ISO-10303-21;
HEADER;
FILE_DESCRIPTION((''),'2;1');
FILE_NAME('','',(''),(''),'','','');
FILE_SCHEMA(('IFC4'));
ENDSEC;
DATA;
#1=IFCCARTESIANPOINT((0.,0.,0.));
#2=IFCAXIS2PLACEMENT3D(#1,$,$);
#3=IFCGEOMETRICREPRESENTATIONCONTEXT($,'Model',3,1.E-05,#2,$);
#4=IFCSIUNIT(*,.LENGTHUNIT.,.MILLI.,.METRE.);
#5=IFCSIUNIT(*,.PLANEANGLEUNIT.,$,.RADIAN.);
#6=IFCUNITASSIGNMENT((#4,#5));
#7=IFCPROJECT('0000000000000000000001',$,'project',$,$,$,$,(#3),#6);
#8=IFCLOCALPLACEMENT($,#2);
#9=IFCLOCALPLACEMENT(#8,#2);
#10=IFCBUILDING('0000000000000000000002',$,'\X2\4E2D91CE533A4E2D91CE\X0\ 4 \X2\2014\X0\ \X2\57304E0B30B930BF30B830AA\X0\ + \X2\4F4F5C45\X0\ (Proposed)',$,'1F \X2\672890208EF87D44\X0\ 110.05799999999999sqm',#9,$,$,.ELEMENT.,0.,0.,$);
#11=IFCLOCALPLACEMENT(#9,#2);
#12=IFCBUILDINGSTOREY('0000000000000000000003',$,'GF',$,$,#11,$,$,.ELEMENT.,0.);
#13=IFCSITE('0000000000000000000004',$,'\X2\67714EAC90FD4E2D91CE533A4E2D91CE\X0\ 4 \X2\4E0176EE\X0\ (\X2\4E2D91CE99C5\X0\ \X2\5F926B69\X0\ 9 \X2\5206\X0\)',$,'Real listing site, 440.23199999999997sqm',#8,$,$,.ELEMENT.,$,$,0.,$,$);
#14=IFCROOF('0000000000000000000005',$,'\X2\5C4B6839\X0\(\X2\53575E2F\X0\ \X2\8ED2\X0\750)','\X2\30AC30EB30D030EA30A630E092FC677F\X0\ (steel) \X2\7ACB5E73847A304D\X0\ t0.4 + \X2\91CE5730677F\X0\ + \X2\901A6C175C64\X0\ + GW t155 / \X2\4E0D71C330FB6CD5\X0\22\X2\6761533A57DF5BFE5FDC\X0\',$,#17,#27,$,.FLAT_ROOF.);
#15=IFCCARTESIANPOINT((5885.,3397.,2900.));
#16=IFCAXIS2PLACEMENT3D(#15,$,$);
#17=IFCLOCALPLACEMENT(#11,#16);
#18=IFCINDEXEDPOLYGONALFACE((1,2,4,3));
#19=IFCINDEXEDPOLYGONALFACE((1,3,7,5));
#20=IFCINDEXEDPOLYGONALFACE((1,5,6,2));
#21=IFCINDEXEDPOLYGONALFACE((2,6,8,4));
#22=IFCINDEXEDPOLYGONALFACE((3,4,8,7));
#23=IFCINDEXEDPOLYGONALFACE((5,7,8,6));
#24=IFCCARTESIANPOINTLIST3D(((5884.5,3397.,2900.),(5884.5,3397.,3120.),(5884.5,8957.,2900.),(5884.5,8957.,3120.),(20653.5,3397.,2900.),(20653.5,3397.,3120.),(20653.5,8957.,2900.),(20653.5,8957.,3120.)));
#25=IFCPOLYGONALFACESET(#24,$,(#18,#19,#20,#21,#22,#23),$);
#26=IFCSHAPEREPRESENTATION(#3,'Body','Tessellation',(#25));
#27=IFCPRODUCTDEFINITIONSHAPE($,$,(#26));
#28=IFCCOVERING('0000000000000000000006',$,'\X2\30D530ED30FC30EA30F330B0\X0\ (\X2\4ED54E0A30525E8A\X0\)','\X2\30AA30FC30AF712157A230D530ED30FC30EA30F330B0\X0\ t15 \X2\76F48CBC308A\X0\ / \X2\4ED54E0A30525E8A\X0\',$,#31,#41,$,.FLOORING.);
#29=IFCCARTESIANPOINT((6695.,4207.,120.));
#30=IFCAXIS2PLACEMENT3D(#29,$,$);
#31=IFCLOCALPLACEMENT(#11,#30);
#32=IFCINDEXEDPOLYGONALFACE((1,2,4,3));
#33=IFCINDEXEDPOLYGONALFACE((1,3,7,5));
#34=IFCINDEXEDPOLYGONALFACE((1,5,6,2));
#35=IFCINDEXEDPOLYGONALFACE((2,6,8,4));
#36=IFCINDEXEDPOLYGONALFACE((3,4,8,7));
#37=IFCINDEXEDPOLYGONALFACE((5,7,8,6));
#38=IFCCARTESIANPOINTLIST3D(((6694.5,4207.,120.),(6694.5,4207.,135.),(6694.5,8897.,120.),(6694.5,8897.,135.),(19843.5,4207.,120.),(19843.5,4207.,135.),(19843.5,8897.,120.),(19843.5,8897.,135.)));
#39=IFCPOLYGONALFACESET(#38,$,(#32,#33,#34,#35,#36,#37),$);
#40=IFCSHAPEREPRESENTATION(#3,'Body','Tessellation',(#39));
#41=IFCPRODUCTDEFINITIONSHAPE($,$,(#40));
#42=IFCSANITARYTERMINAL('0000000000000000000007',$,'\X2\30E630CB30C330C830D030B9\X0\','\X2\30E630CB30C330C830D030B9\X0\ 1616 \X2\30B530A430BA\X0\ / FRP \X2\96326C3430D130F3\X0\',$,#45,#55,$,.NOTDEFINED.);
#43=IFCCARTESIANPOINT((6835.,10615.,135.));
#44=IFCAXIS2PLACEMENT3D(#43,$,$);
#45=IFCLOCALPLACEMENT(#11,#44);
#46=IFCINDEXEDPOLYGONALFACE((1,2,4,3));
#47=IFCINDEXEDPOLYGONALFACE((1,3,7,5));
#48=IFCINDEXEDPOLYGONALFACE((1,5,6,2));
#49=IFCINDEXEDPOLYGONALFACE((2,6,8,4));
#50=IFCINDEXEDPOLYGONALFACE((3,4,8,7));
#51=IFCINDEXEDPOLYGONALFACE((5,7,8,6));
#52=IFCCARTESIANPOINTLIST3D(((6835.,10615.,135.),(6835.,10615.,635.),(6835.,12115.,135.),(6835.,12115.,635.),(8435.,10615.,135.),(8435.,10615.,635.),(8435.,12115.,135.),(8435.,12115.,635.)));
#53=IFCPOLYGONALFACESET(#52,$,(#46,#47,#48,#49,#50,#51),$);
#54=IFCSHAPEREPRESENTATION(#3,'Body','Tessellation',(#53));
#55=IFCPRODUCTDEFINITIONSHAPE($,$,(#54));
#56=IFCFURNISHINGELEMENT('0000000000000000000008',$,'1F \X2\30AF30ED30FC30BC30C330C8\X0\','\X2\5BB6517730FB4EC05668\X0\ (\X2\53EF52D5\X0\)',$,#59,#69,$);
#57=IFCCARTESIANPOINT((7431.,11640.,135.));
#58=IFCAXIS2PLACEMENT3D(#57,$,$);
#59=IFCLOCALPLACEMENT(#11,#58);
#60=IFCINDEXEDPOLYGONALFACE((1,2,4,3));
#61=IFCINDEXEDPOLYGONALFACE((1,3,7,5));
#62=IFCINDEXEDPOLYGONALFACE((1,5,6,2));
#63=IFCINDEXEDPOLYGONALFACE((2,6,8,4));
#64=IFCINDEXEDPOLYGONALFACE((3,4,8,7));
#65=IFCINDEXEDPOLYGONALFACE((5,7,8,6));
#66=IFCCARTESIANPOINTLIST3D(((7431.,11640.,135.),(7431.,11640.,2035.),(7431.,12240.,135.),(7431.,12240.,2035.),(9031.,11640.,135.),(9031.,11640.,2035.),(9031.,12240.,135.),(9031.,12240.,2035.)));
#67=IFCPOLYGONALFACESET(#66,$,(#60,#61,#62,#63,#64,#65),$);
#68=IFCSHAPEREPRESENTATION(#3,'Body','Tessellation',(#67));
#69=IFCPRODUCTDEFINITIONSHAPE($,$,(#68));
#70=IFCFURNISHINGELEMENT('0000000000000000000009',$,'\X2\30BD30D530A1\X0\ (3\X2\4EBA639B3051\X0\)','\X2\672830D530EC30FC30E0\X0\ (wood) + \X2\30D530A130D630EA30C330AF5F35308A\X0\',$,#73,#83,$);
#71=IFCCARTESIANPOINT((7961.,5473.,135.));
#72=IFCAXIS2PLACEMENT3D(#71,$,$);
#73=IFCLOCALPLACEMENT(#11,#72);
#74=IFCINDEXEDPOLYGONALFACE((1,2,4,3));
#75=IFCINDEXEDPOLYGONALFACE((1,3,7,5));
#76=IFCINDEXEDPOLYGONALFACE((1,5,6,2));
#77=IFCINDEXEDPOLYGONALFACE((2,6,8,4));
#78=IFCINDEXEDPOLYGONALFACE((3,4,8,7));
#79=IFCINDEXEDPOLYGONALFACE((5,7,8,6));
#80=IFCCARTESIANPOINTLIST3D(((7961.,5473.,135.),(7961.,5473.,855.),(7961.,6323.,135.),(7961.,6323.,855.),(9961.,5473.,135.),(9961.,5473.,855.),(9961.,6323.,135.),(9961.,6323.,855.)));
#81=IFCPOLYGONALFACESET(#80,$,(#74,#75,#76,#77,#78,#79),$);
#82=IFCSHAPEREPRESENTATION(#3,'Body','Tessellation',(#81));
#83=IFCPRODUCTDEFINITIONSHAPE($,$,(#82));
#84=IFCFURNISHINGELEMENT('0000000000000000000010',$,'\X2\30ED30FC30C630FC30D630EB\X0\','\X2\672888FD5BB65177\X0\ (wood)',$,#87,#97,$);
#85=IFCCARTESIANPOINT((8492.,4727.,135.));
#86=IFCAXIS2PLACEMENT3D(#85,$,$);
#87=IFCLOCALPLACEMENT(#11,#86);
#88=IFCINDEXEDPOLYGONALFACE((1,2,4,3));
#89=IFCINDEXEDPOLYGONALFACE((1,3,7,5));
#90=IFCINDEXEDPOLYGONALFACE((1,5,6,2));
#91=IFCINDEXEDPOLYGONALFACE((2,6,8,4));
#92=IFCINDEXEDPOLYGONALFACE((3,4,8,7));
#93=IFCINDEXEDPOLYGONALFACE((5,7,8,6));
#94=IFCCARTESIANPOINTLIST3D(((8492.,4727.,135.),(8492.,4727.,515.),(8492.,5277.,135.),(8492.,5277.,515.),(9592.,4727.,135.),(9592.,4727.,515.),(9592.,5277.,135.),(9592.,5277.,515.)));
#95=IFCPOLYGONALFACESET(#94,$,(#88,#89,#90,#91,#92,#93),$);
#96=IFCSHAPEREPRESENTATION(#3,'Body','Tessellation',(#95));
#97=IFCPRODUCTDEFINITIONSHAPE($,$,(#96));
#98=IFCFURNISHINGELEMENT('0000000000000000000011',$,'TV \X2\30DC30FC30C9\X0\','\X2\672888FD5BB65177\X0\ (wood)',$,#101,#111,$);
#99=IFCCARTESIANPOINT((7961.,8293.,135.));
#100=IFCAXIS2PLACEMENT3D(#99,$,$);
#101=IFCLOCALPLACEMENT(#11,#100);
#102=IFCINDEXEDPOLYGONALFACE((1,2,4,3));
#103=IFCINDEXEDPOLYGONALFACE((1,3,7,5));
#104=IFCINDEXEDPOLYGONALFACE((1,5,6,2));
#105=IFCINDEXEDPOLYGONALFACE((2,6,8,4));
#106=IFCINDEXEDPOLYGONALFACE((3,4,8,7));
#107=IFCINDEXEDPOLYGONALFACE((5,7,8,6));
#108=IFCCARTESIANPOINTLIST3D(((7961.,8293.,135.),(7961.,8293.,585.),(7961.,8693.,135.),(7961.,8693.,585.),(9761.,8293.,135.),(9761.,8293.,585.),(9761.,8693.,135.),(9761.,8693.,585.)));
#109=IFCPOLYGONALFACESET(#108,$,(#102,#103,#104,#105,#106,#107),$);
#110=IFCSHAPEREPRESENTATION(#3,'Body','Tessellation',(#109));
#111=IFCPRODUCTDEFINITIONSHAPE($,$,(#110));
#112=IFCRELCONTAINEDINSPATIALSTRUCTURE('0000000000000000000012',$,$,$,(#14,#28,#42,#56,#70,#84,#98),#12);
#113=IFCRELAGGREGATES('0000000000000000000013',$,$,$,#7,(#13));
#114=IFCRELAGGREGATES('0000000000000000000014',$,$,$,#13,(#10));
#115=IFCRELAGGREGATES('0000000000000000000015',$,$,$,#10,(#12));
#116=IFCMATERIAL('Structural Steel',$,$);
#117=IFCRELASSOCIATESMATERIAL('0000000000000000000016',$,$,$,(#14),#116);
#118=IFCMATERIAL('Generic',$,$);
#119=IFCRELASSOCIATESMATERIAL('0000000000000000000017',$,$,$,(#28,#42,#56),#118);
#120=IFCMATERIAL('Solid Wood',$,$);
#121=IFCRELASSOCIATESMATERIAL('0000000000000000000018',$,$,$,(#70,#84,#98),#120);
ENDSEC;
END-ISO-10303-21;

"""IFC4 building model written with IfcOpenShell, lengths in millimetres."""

from ifc_helpers import new_model, si_unit, frame, frame_2d, origin, place, context, project, spatial, rectangle, extrude, material, element, save


model = new_model("IFC4")

# Units and contexts
model_context = context("Model", 3, precision=1e-05, world=origin())
ifc_project = project(units=[si_unit("LENGTHUNIT", "METRE", prefix="MILLI"), si_unit("PLANEANGLEUNIT", "RADIAN")], contexts=[model_context])

# Site, building, storey
site_placement = place(None, origin())
site = spatial("IfcSite", under=ifc_project, at=site_placement, Name="東京都中野区中野 4 丁目 (中野駅 徒歩 9 分)", ObjectType="Real listing site, 440.23199999999997sqm", CompositionType="ELEMENT", RefElevation=0.0)
building_placement = place(site_placement, origin())
building = spatial("IfcBuilding", under=site, at=building_placement, Name="中野区中野 4 — 地下スタジオ + 住居 (Proposed)", ObjectType="1F 木造軸組 110.05799999999999sqm", CompositionType="ELEMENT", ElevationOfRefHeight=0.0, ElevationOfTerrain=0.0)
storey_placement = place(building_placement, origin())
storey = spatial("IfcBuildingStorey", under=building, at=storey_placement, Name="GF", CompositionType="ELEMENT", Elevation=0.0)

# Shared definitions
ifc_material_1 = material(Name="Solid Wood")

# Roof
ifc_material_2 = material(Name="Structural Steel")
roof_1_placement = place(storey_placement, frame((5885.0, 3397.0, 2900.0)))
element("IfcRoof", 1, at=roof_1_placement, inside=storey, material=ifc_material_2, Name="屋根(南帯 軒750)", Description="ガルバリウム鋼板 (steel) 立平葺き t0.4 + 野地板 + 通気層 + GW t155 / 不燃・法22条区域対応", PredefinedType="FLAT_ROOF", context=model_context, shape_type="SweptSolid", body=[
    extrude(rectangle(XDim=14769.0, YDim=5560.0, at=frame_2d((7384.0, 2780.0))), frame((5885.0, 3397.0, 2900.0)), (0.0, 0.0, 1.0), 220.0),
])

# Covering
ifc_material_3 = material(Name="Generic")
covering_1_placement = place(storey_placement, frame((6695.0, 4207.0, 120.0)))
element("IfcCovering", 2, at=covering_1_placement, inside=storey, material=ifc_material_3, Name="フローリング (仕上げ床)", Description="オーク無垢フローリング t15 直貼り / 仕上げ床", PredefinedType="FLOORING", context=model_context, shape_type="SweptSolid", body=[
    extrude(rectangle(XDim=13149.0, YDim=4690.0, at=frame_2d((6574.0, 2345.0))), frame((6695.0, 4207.0, 120.0)), (0.0, 0.0, 1.0), 15.0),
])

# Sanitary terminal
sanitary_terminal_placement = place(storey_placement, frame((6835.0, 10615.0, 135.0)))
element("IfcSanitaryTerminal", 3, at=sanitary_terminal_placement, inside=storey, material=ifc_material_3, Name="ユニットバス", Description="ユニットバス 1616 サイズ / FRP 防水パン", PredefinedType="NOTDEFINED", context=model_context, shape_type="SweptSolid", body=[
    extrude(rectangle(XDim=1600.0, YDim=1500.0, at=frame_2d((800.0, 750.0))), frame((6835.0, 10615.0, 135.0)), (0.0, 0.0, 1.0), 500.0),
])

# Furnishing elements
furnishing_1_placement = place(storey_placement, frame((7431.0, 11640.0, 135.0)))
element("IfcFurnishingElement", 4, at=furnishing_1_placement, inside=storey, material=ifc_material_3, Name="1F クローゼット", Description="家具・什器 (可動)", context=model_context, shape_type="SweptSolid", body=[
    extrude(rectangle(XDim=1600.0, YDim=600.0, at=frame_2d((800.0, 300.0))), frame((7431.0, 11640.0, 135.0)), (0.0, 0.0, 1.0), 1900.0),
])
furnishing_2_placement = place(storey_placement, frame((7961.0, 5473.0, 135.0)))
element("IfcFurnishingElement", 5, at=furnishing_2_placement, inside=storey, material=ifc_material_1, Name="ソファ (3人掛け)", Description="木フレーム (wood) + ファブリック張り", context=model_context, shape_type="SweptSolid", body=[
    extrude(rectangle(XDim=2000.0, YDim=850.0, at=frame_2d((1000.0, 425.0))), frame((7961.0, 5473.0, 135.0)), (0.0, 0.0, 1.0), 720.0),
])
furnishing_3_placement = place(storey_placement, frame((8492.0, 4727.0, 135.0)))
element("IfcFurnishingElement", 6, at=furnishing_3_placement, inside=storey, material=ifc_material_1, Name="ローテーブル", Description="木製家具 (wood)", context=model_context, shape_type="SweptSolid", body=[
    extrude(rectangle(XDim=1100.0, YDim=550.0, at=frame_2d((550.0, 275.0))), frame((8492.0, 4727.0, 135.0)), (0.0, 0.0, 1.0), 380.0),
])
furnishing_4_placement = place(storey_placement, frame((7961.0, 8293.0, 135.0)))
element("IfcFurnishingElement", 7, at=furnishing_4_placement, inside=storey, material=ifc_material_1, Name="TV ボード", Description="木製家具 (wood)", context=model_context, shape_type="SweptSolid", body=[
    extrude(rectangle(XDim=1800.0, YDim=400.0, at=frame_2d((900.0, 200.0))), frame((7961.0, 8293.0, 135.0)), (0.0, 0.0, 1.0), 450.0),
])

save(model, "model.ifc")
